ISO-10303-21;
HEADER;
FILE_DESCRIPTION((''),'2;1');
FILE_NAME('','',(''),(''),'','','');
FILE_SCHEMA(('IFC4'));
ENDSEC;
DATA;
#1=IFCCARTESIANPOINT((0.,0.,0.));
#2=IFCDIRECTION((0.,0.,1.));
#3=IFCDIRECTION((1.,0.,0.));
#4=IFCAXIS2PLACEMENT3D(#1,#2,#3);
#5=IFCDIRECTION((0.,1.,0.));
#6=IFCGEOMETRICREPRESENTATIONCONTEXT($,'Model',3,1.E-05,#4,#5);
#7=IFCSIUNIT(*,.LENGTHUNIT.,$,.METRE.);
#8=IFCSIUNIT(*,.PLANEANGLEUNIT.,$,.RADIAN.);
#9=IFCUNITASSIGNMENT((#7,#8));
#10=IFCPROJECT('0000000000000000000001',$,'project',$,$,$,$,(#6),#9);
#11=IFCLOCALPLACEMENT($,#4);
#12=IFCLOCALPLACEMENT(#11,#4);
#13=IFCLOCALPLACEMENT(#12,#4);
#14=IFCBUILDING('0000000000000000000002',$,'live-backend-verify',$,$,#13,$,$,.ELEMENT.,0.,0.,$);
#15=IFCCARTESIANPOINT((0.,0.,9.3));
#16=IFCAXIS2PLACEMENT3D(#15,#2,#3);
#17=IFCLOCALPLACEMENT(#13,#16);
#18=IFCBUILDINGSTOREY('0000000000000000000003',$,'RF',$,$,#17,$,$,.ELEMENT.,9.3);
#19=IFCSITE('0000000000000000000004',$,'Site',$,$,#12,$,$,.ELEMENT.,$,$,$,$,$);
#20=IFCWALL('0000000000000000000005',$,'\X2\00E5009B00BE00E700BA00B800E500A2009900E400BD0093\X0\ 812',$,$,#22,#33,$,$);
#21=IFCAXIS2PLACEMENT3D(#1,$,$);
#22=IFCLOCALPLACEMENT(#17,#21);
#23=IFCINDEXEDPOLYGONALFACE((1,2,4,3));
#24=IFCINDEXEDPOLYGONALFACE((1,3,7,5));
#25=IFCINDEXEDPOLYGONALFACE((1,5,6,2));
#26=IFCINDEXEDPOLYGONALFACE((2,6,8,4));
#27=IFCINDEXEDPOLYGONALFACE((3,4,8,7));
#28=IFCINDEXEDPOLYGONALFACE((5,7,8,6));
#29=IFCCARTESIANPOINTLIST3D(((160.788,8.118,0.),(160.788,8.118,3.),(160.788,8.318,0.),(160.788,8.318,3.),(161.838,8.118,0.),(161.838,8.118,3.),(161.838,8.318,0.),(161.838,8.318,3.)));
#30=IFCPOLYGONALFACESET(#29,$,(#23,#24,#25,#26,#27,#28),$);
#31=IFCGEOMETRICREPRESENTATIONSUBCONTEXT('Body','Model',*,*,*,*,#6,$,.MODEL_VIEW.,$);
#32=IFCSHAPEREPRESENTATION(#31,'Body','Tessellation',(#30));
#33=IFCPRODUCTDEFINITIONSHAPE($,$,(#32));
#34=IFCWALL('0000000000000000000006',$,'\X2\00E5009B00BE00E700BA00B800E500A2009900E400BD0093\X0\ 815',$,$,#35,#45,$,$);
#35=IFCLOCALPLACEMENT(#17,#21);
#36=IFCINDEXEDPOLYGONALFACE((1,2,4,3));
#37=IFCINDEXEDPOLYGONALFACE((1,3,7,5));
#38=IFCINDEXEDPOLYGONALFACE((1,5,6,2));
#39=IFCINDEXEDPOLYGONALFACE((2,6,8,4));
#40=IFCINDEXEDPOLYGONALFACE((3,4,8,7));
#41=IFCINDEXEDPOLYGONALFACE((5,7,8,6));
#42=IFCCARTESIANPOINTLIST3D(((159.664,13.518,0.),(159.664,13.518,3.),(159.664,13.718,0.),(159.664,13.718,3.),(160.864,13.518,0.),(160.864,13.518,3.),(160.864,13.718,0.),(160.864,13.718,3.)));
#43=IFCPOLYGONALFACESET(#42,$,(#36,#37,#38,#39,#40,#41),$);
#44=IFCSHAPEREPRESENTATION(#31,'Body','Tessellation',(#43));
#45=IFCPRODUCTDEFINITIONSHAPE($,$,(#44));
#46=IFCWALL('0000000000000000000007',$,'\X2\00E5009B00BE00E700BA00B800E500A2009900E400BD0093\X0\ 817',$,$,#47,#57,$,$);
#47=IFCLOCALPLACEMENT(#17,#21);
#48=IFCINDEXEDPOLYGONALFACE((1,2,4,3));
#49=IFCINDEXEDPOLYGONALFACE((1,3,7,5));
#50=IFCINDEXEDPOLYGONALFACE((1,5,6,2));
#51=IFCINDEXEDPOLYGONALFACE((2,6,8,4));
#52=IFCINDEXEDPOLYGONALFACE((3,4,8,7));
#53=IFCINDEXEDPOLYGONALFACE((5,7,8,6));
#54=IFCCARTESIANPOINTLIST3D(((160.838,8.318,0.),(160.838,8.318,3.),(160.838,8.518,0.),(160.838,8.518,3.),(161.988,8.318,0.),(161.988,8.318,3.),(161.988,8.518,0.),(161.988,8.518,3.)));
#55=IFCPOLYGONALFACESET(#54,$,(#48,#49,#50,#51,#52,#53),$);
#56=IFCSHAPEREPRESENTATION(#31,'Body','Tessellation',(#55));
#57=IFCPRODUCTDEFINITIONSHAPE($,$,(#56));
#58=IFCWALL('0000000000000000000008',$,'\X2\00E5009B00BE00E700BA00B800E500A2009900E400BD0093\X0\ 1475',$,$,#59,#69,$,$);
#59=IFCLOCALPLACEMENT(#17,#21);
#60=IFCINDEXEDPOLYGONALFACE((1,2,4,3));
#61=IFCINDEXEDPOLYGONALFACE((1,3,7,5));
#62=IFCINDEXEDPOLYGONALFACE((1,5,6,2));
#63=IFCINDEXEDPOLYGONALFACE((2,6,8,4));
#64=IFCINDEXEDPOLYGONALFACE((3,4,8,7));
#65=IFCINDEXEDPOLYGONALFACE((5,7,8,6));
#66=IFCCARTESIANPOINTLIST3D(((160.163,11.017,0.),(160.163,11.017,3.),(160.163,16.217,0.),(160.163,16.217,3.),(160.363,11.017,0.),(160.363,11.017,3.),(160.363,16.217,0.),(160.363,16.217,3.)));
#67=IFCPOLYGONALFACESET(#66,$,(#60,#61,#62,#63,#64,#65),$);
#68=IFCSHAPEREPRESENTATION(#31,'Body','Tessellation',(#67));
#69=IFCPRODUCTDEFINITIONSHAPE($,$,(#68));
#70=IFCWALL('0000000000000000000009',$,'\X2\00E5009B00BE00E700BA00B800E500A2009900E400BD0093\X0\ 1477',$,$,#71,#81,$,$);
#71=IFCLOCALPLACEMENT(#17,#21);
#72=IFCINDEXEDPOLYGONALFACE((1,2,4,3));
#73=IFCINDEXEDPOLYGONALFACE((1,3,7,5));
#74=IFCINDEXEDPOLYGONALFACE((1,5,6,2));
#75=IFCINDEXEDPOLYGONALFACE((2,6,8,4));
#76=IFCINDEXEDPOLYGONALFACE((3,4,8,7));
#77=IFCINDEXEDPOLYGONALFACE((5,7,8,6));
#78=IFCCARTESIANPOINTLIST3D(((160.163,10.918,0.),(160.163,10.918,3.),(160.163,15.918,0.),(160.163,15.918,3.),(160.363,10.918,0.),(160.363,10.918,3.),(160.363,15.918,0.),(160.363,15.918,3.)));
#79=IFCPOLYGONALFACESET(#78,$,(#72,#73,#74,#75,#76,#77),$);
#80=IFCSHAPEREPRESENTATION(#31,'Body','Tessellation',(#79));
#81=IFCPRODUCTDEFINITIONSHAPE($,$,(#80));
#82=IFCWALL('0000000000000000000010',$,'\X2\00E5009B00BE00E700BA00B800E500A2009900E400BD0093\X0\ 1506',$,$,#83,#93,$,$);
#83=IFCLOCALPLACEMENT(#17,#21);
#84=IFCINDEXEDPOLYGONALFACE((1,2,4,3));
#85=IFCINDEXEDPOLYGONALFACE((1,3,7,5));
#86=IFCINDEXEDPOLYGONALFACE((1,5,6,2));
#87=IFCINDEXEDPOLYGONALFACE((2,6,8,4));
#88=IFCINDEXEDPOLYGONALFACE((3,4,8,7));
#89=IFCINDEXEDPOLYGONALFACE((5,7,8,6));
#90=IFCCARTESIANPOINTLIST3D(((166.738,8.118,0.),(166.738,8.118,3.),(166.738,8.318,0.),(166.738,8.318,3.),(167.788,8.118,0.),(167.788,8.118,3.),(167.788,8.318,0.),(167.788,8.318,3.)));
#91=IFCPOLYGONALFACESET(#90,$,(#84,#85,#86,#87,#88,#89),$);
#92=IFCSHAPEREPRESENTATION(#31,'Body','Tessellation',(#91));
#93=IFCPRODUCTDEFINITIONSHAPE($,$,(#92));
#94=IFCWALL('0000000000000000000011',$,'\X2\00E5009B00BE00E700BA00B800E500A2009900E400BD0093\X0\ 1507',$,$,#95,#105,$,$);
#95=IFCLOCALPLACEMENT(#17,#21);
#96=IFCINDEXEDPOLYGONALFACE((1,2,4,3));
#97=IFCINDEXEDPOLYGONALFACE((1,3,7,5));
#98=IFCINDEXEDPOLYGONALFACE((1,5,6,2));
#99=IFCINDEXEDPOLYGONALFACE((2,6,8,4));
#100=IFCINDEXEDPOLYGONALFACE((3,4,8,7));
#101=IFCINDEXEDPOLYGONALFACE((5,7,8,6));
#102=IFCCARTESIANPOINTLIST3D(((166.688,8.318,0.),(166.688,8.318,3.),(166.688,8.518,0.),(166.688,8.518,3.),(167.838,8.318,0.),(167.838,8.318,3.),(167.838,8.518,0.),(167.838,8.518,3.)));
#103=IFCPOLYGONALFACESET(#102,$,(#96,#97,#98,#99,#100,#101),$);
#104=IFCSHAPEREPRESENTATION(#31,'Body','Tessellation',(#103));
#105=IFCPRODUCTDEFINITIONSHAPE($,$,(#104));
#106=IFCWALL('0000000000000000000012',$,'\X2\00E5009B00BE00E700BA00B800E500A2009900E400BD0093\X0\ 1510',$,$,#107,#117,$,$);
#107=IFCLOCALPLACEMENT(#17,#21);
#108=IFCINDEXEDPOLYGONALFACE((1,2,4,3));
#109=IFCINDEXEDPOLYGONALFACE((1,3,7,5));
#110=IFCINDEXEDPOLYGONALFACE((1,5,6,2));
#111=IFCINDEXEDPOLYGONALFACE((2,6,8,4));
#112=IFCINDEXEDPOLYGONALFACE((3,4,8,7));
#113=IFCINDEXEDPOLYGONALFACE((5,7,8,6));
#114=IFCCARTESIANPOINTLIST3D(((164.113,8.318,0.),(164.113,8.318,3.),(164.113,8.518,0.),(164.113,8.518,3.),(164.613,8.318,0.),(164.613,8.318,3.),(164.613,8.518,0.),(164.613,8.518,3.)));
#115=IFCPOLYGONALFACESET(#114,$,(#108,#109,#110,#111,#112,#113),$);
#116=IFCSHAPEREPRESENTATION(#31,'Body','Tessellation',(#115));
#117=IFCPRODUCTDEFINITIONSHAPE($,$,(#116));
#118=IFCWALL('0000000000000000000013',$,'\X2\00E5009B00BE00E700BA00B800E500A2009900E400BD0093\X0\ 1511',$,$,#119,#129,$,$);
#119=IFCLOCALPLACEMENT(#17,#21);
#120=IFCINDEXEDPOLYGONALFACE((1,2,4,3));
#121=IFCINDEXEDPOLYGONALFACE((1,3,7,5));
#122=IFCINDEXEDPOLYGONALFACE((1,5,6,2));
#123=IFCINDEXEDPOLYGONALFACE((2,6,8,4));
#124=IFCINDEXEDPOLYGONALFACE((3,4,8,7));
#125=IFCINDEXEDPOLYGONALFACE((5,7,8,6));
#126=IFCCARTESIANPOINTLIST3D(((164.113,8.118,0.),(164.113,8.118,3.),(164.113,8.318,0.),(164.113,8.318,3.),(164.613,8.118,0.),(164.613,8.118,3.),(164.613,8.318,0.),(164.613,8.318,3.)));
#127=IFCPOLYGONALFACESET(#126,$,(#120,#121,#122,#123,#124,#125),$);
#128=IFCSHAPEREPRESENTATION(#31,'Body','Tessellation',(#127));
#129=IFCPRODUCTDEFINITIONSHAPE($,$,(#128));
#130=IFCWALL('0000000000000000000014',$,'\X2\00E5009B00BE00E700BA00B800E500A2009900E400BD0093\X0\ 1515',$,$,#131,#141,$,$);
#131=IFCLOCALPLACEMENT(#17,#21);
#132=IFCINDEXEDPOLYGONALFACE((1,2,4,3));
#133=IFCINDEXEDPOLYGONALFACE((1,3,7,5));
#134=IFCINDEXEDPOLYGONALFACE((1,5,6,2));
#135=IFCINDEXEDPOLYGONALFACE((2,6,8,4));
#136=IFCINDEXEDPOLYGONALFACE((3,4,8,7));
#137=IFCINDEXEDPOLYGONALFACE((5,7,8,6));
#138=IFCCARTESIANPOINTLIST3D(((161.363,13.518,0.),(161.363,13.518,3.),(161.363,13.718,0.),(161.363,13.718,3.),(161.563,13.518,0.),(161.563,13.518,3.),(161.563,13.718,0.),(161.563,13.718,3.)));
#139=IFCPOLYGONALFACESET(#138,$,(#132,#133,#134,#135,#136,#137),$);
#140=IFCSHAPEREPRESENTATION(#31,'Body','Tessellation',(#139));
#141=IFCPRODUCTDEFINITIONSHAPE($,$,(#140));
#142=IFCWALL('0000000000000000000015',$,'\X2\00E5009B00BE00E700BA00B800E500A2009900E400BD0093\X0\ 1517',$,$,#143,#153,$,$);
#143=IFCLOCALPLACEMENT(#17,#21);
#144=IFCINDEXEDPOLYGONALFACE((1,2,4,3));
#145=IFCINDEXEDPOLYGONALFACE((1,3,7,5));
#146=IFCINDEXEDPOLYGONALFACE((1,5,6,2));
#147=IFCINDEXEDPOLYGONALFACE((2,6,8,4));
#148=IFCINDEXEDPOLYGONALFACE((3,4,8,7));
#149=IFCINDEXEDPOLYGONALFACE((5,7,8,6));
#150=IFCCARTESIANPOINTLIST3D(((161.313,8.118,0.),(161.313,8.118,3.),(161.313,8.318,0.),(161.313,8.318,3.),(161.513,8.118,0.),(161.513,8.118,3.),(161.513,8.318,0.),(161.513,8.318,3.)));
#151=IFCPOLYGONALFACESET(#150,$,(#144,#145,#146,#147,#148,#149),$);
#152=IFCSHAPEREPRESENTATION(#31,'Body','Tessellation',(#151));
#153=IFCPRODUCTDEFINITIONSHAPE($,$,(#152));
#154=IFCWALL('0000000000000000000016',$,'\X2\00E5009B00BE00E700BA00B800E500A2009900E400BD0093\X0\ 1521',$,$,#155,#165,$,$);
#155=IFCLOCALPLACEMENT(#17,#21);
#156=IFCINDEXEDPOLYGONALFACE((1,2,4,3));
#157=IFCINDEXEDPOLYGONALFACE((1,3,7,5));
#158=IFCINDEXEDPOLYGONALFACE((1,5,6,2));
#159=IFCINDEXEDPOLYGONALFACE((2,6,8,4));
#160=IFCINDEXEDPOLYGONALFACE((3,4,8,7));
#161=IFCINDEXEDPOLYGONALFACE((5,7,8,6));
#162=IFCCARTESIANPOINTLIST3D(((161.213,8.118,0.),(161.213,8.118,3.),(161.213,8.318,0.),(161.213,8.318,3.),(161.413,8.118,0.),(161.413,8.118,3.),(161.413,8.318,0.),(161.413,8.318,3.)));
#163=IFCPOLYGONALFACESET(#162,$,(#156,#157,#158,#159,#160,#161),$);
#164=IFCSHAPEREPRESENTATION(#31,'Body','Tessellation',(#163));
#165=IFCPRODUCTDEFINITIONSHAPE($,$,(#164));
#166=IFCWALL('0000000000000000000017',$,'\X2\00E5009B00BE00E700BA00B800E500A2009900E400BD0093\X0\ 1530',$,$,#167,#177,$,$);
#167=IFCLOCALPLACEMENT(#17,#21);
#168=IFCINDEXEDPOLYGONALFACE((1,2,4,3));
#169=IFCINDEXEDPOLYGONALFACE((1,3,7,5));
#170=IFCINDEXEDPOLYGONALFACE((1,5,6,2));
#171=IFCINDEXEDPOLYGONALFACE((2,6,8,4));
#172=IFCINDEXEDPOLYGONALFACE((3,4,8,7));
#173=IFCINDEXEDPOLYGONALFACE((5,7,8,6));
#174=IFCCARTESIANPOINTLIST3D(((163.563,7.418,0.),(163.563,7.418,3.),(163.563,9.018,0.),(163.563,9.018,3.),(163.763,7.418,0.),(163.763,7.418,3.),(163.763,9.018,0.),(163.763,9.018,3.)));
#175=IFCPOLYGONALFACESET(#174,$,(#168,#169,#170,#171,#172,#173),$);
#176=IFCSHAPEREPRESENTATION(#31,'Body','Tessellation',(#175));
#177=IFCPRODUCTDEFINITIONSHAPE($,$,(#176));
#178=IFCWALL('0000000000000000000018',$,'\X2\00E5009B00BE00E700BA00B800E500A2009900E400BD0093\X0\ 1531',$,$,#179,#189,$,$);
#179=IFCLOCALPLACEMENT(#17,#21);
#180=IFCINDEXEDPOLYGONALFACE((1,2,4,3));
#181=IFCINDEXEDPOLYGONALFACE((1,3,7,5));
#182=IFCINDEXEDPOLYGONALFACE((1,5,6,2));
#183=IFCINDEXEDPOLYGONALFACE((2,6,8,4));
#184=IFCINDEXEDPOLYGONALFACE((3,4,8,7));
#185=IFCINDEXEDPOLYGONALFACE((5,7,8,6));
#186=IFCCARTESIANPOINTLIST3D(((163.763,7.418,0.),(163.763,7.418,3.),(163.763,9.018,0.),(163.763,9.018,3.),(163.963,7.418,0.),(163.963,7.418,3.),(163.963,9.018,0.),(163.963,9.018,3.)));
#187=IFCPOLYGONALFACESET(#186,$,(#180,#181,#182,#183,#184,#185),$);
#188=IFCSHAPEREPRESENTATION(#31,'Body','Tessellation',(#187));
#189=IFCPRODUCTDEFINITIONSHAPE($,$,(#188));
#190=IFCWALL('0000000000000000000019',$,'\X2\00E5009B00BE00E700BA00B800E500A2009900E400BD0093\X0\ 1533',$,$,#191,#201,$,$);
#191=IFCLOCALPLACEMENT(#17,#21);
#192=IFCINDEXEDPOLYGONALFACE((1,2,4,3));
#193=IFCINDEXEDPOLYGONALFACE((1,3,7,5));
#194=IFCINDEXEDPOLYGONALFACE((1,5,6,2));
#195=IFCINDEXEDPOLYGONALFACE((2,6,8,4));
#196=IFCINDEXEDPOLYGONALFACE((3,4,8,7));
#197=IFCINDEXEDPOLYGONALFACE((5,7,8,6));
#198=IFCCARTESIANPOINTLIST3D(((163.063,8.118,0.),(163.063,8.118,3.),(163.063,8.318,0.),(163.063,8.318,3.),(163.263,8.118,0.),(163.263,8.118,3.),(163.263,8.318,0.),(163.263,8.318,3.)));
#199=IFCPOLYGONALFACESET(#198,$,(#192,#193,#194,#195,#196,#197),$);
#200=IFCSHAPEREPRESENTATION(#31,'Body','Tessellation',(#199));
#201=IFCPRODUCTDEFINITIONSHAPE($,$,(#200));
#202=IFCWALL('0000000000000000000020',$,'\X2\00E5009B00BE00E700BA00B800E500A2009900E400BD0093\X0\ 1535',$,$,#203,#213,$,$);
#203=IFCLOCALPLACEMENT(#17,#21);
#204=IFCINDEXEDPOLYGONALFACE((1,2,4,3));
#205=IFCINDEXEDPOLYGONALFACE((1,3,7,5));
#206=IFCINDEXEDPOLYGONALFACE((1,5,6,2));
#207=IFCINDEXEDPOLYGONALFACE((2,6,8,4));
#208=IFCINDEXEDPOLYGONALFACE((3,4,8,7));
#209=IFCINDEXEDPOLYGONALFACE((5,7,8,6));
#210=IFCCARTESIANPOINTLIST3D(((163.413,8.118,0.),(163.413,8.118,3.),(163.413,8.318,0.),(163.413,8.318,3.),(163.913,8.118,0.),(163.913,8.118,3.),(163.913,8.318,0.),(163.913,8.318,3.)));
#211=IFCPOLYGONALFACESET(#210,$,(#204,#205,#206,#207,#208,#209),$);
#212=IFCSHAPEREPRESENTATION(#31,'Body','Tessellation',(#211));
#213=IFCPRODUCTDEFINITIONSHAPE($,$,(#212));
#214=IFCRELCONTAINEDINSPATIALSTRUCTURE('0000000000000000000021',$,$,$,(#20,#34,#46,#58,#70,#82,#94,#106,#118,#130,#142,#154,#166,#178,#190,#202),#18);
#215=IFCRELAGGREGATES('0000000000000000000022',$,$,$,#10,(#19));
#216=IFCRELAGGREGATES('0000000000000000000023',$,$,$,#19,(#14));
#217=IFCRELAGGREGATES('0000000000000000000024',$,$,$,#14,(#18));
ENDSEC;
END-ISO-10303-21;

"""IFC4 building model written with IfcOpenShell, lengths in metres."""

from ifc_helpers import new_model, si_unit, direction, frame, frame_2d, origin_with_axes, place, context, subcontext, project, spatial, rectangle, extrude, element, save


model = new_model("IFC4")

# Units and contexts
model_context = context("Model", 3, precision=1e-05, world=origin_with_axes(), true_north=direction((0.0, 1.0, 0.0)))
body_context = subcontext(model_context, "Body", "Model", "MODEL_VIEW")
ifc_project = project(units=[si_unit("LENGTHUNIT", "METRE"), si_unit("PLANEANGLEUNIT", "RADIAN")], contexts=[model_context])

# Site, building, storey
placement = place(None, origin_with_axes())
site_placement = place(placement, origin_with_axes())
site = spatial("IfcSite", under=ifc_project, at=site_placement, Name="Site", CompositionType="ELEMENT")
building_placement = place(site_placement, origin_with_axes())
building = spatial("IfcBuilding", under=site, at=building_placement, Name="live-backend-verify", CompositionType="ELEMENT", ElevationOfRefHeight=0.0, ElevationOfTerrain=0.0)
storey_placement = place(building_placement, frame((0.0, 0.0, 9.3), z_axis=(0.0, 0.0, 1.0), x_axis=(1.0, 0.0, 0.0)))
storey = spatial("IfcBuildingStorey", under=building, at=storey_placement, Name="RF", CompositionType="ELEMENT", Elevation=9.3)

# Walls
wall_1_placement = place(storey_placement, frame((161.313, 8.218, 0.0), z_axis=(0.0, 0.0, 1.0), x_axis=(-1.0, 0.0, 0.0)))
element("IfcWall", 1, at=wall_1_placement, inside=storey, Name="å\u009b¾çº¸å¢\u0099ä½\u0093 812", context=body_context, shape_type="SweptSolid", body=[
    extrude(rectangle(XDim=1.05, YDim=0.2, at=frame_2d((0.0, 0.0), x_axis=(1.0, 0.0, 0.0))), frame((0.0, 0.0, 0.0), z_axis=(0.0, 0.0, 1.0)), (0.0, 0.0, 1.0), 3.0),
])
wall_2_placement = place(storey_placement, frame((160.264, 13.618, 0.0), z_axis=(0.0, 0.0, 1.0), x_axis=(1.0, 0.0, 0.0)))
element("IfcWall", 2, at=wall_2_placement, inside=storey, Name="å\u009b¾çº¸å¢\u0099ä½\u0093 815", context=body_context, shape_type="SweptSolid", body=[
    extrude(rectangle(XDim=1.2, YDim=0.2, at=frame_2d((0.0, 0.0), x_axis=(1.0, 0.0, 0.0))), frame((0.0, 0.0, 0.0), z_axis=(0.0, 0.0, 1.0)), (0.0, 0.0, 1.0), 3.0),
])
wall_3_placement = place(storey_placement, frame((161.413, 8.418, 0.0), z_axis=(0.0, 0.0, 1.0), x_axis=(-1.0, 0.0, 0.0)))
element("IfcWall", 3, at=wall_3_placement, inside=storey, Name="å\u009b¾çº¸å¢\u0099ä½\u0093 817", context=body_context, shape_type="SweptSolid", body=[
    extrude(rectangle(XDim=1.15, YDim=0.2, at=frame_2d((0.0, 0.0), x_axis=(1.0, 0.0, 0.0))), frame((0.0, 0.0, 0.0), z_axis=(0.0, 0.0, 1.0)), (0.0, 0.0, 1.0), 3.0),
])
wall_4_placement = place(storey_placement, frame((160.263, 13.617, 0.0), z_axis=(0.0, 0.0, 1.0), x_axis=(0.0, -1.0, 0.0)))
element("IfcWall", 4, at=wall_4_placement, inside=storey, Name="å\u009b¾çº¸å¢\u0099ä½\u0093 1475", context=body_context, shape_type="SweptSolid", body=[
    extrude(rectangle(XDim=5.2, YDim=0.2, at=frame_2d((0.0, 0.0), x_axis=(1.0, 0.0, 0.0))), frame((0.0, 0.0, 0.0), z_axis=(0.0, 0.0, 1.0)), (0.0, 0.0, 1.0), 3.0),
])
wall_5_placement = place(storey_placement, frame((160.263, 13.418, 0.0), z_axis=(0.0, 0.0, 1.0), x_axis=(0.0, -1.0, 0.0)))
element("IfcWall", 5, at=wall_5_placement, inside=storey, Name="å\u009b¾çº¸å¢\u0099ä½\u0093 1477", context=body_context, shape_type="SweptSolid", body=[
    extrude(rectangle(XDim=5.0, YDim=0.2, at=frame_2d((0.0, 0.0), x_axis=(1.0, 0.0, 0.0))), frame((0.0, 0.0, 0.0), z_axis=(0.0, 0.0, 1.0)), (0.0, 0.0, 1.0), 3.0),
])
wall_6_placement = place(storey_placement, frame((167.263, 8.218, 0.0), z_axis=(0.0, 0.0, 1.0), x_axis=(-1.0, 0.0, 0.0)))
element("IfcWall", 6, at=wall_6_placement, inside=storey, Name="å\u009b¾çº¸å¢\u0099ä½\u0093 1506", context=body_context, shape_type="SweptSolid", body=[
    extrude(rectangle(XDim=1.05, YDim=0.2, at=frame_2d((0.0, 0.0), x_axis=(1.0, 0.0, 0.0))), frame((0.0, 0.0, 0.0), z_axis=(0.0, 0.0, 1.0)), (0.0, 0.0, 1.0), 3.0),
])
wall_7_placement = place(storey_placement, frame((167.263, 8.418, 0.0), z_axis=(0.0, 0.0, 1.0), x_axis=(-1.0, 0.0, 0.0)))
element("IfcWall", 7, at=wall_7_placement, inside=storey, Name="å\u009b¾çº¸å¢\u0099ä½\u0093 1507", context=body_context, shape_type="SweptSolid", body=[
    extrude(rectangle(XDim=1.15, YDim=0.2, at=frame_2d((0.0, 0.0), x_axis=(1.0, 0.0, 0.0))), frame((0.0, 0.0, 0.0), z_axis=(0.0, 0.0, 1.0)), (0.0, 0.0, 1.0), 3.0),
])
for number, where, z_axis, x_axis, name in (
    (8, (164.363, 8.418, 0.0), (0.0, 0.0, 1.0), (-1.0, 0.0, 0.0), "å\u009b¾çº¸å¢\u0099ä½\u0093 1510"),
    (9, (164.363, 8.218, 0.0), (0.0, 0.0, 1.0), (-1.0, 0.0, 0.0), "å\u009b¾çº¸å¢\u0099ä½\u0093 1511"),
):
    element("IfcWall", number, at=place(storey_placement, frame(where, z_axis=z_axis, x_axis=x_axis)), inside=storey, Name=name, context=body_context, shape_type="SweptSolid", body=[
        extrude(rectangle(XDim=0.5, YDim=0.2, at=frame_2d((0.0, 0.0), x_axis=(1.0, 0.0, 0.0))), frame((0.0, 0.0, 0.0), z_axis=(0.0, 0.0, 1.0)), (0.0, 0.0, 1.0), 3.0),
    ])
for number, where, z_axis, x_axis, name in (
    (10, (161.463, 13.618, 0.0), (0.0, 0.0, 1.0), (0.0, 1.0, 0.0), "å\u009b¾çº¸å¢\u0099ä½\u0093 1515"),
    (11, (161.413, 8.218, 0.0), (0.0, 0.0, 1.0), (0.0, 1.0, 0.0), "å\u009b¾çº¸å¢\u0099ä½\u0093 1517"),
    (12, (161.313, 8.218, 0.0), (0.0, 0.0, 1.0), (0.0, -1.0, 0.0), "å\u009b¾çº¸å¢\u0099ä½\u0093 1521"),
):
    element("IfcWall", number, at=place(storey_placement, frame(where, z_axis=z_axis, x_axis=x_axis)), inside=storey, Name=name, context=body_context, shape_type="SweptSolid", body=[
        extrude(rectangle(XDim=0.2, YDim=0.2, at=frame_2d((0.0, 0.0), x_axis=(1.0, 0.0, 0.0))), frame((0.0, 0.0, 0.0), z_axis=(0.0, 0.0, 1.0)), (0.0, 0.0, 1.0), 3.0),
    ])
for number, where, z_axis, x_axis, name in (
    (13, (163.663, 8.218, 0.0), (0.0, 0.0, 1.0), (0.0, -1.0, 0.0), "å\u009b¾çº¸å¢\u0099ä½\u0093 1530"),
    (14, (163.863, 8.218, 0.0), (0.0, 0.0, 1.0), (0.0, -1.0, 0.0), "å\u009b¾çº¸å¢\u0099ä½\u0093 1531"),
):
    element("IfcWall", number, at=place(storey_placement, frame(where, z_axis=z_axis, x_axis=x_axis)), inside=storey, Name=name, context=body_context, shape_type="SweptSolid", body=[
        extrude(rectangle(XDim=1.6, YDim=0.2, at=frame_2d((0.0, 0.0), x_axis=(1.0, 0.0, 0.0))), frame((0.0, 0.0, 0.0), z_axis=(0.0, 0.0, 1.0)), (0.0, 0.0, 1.0), 3.0),
    ])
wall_8_placement = place(storey_placement, frame((163.163, 8.218, 0.0), z_axis=(0.0, 0.0, 1.0), x_axis=(0.0, 1.0, 0.0)))
element("IfcWall", 15, at=wall_8_placement, inside=storey, Name="å\u009b¾çº¸å¢\u0099ä½\u0093 1533", context=body_context, shape_type="SweptSolid", body=[
    extrude(rectangle(XDim=0.2, YDim=0.2, at=frame_2d((0.0, 0.0), x_axis=(1.0, 0.0, 0.0))), frame((0.0, 0.0, 0.0), z_axis=(0.0, 0.0, 1.0)), (0.0, 0.0, 1.0), 3.0),
])
for number, where, z_axis, x_axis, name in (
    (16, (163.663, 8.218, 0.0), (0.0, 0.0, 1.0), (-1.0, 0.0, 0.0), "å\u009b¾çº¸å¢\u0099ä½\u0093 1535"),
):
    element("IfcWall", number, at=place(storey_placement, frame(where, z_axis=z_axis, x_axis=x_axis)), inside=storey, Name=name, context=body_context, shape_type="SweptSolid", body=[
        extrude(rectangle(XDim=0.5, YDim=0.2, at=frame_2d((0.0, 0.0), x_axis=(1.0, 0.0, 0.0))), frame((0.0, 0.0, 0.0), z_axis=(0.0, 0.0, 1.0)), (0.0, 0.0, 1.0), 3.0),
    ])

save(model, "model.ifc")
